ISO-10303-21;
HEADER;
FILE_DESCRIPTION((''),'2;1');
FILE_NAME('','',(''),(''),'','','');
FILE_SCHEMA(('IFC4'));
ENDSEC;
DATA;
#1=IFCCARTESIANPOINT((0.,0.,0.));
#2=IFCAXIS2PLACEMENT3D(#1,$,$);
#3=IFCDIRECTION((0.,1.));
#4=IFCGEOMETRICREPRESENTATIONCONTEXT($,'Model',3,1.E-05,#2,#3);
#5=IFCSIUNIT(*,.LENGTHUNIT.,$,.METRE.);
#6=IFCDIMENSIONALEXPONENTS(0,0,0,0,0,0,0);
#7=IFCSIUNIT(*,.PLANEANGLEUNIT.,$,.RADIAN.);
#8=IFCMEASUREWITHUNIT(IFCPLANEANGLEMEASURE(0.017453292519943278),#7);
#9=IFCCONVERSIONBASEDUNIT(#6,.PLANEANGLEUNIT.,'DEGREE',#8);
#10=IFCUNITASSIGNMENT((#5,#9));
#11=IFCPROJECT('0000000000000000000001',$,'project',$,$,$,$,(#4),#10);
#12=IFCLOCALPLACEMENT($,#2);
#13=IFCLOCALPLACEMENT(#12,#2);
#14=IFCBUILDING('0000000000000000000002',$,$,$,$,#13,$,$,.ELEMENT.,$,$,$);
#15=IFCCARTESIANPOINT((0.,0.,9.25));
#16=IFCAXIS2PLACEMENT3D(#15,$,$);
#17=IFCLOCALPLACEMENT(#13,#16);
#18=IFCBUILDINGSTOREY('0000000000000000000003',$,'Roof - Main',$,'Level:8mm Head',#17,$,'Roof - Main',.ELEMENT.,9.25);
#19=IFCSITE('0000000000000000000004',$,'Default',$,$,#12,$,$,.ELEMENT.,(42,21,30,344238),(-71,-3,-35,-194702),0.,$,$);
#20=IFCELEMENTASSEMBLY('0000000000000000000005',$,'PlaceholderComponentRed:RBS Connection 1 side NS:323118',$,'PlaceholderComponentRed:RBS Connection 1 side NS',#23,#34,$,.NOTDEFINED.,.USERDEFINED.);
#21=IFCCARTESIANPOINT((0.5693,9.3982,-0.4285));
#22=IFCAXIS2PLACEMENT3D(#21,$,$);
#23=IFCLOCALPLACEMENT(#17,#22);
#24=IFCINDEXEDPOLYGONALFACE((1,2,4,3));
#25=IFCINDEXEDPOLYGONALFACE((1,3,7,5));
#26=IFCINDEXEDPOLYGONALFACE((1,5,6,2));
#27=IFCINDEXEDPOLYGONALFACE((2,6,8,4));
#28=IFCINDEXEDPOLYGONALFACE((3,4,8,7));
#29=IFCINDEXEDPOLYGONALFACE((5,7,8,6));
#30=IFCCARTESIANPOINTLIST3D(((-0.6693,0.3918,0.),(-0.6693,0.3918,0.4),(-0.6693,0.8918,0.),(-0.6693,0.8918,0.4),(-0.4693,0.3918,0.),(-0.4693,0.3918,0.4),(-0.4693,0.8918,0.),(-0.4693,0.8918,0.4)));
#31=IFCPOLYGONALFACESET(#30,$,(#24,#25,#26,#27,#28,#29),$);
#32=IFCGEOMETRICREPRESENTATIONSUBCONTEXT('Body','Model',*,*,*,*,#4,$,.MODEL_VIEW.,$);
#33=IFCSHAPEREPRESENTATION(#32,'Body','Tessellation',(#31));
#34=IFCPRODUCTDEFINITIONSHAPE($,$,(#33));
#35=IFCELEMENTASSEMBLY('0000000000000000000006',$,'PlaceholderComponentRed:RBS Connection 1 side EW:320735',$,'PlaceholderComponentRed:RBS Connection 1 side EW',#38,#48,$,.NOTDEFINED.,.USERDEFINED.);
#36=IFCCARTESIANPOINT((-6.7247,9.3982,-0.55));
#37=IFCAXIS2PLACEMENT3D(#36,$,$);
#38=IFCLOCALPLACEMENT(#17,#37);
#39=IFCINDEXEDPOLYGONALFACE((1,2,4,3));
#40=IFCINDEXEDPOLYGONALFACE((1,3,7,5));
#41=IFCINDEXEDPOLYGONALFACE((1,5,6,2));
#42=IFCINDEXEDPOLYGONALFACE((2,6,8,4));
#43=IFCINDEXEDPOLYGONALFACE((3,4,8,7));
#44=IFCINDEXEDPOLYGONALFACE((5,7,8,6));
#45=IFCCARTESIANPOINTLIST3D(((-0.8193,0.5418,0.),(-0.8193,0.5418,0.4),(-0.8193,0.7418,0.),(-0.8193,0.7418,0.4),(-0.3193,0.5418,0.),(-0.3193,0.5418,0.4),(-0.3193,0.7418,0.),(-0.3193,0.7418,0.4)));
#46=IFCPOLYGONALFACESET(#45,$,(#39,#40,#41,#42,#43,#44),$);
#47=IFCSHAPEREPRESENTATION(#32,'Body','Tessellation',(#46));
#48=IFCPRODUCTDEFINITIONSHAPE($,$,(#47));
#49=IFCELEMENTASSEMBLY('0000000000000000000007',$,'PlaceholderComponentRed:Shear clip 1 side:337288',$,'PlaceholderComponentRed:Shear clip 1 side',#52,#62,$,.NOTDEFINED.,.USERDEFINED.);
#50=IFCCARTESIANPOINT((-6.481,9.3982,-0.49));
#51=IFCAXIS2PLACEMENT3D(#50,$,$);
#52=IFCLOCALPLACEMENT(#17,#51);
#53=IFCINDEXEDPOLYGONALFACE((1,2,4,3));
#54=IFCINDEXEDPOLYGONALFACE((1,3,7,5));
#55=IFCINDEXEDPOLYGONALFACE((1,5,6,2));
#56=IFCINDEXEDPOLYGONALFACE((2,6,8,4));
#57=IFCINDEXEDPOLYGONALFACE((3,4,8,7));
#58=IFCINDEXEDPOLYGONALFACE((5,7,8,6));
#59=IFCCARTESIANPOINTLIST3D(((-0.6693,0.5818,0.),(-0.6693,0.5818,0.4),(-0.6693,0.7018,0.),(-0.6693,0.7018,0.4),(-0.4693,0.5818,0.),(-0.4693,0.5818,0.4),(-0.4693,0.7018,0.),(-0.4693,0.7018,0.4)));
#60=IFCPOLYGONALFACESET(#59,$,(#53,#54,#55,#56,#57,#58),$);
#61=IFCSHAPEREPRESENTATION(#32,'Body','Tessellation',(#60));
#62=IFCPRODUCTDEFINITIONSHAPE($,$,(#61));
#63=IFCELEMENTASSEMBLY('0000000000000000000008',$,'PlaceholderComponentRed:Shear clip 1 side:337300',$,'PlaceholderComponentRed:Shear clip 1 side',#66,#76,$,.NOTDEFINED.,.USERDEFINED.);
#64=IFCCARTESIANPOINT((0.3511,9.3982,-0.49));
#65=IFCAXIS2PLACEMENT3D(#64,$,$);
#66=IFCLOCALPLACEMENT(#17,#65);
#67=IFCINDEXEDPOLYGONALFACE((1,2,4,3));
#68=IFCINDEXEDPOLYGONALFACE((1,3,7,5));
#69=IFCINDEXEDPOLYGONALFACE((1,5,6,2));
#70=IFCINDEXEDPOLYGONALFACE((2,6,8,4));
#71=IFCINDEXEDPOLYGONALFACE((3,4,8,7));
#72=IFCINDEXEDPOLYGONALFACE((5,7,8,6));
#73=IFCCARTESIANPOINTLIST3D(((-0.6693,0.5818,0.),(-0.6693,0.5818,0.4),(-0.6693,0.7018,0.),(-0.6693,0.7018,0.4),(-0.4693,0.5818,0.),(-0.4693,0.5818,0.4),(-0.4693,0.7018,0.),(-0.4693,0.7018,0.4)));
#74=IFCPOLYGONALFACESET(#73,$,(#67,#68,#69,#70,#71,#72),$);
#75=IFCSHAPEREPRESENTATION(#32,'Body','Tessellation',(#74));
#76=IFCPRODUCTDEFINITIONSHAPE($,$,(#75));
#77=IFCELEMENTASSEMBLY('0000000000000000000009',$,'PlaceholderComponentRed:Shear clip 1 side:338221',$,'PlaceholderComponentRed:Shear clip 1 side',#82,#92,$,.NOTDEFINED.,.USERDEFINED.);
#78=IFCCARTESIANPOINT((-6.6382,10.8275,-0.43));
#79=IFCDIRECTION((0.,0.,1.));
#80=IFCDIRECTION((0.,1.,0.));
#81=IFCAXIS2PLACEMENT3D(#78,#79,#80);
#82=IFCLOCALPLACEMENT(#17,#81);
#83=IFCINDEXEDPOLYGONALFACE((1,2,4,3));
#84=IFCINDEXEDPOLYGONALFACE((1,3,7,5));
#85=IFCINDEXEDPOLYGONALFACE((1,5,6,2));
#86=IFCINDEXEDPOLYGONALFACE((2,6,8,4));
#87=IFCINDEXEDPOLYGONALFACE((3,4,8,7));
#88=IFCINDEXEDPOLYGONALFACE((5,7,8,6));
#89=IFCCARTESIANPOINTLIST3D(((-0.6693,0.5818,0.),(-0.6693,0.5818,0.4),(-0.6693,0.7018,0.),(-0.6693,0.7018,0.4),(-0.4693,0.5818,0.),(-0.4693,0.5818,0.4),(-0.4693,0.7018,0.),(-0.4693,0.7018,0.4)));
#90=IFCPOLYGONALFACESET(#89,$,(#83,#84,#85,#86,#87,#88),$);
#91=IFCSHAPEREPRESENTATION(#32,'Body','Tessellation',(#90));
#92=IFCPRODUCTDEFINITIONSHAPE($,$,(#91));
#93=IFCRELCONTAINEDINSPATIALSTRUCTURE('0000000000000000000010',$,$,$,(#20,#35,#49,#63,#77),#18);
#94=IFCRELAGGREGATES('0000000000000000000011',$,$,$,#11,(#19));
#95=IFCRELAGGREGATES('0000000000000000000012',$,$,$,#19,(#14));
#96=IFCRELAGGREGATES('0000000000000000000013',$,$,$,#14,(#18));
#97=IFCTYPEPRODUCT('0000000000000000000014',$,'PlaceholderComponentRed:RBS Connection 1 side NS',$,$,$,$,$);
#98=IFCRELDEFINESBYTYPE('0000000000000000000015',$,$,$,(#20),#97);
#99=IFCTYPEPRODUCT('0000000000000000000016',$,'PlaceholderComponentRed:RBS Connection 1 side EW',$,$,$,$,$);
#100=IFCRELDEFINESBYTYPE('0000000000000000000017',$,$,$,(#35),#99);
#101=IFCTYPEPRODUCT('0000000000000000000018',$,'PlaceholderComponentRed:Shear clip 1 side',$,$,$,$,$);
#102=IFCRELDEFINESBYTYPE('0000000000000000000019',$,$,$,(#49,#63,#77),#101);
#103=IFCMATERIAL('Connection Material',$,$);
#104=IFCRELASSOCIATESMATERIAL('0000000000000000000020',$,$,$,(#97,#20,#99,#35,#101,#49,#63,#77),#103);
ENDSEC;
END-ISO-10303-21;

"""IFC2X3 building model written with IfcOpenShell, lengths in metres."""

from ifc_helpers import new_model, entity, si_unit, converted_unit, direction, frame, frame_2d, origin, place, context, subcontext, project, spatial, rectangle, extrude, source, transform, mapped, material, type_object, type_shapes, element, save


model = new_model("IFC2X3")

# Units and contexts
model_context = context("Model", 3, precision=1e-05, world=origin(), true_north=direction((0.0, 1.0)))
body_context = subcontext(model_context, "Body", "Model", "MODEL_VIEW")
ifc_project = project(units=[si_unit("LENGTHUNIT", "METRE"), converted_unit("PLANEANGLEUNIT", "DEGREE", entity("IfcPlaneAngleMeasure", 0.017453292519943278), si_unit("PLANEANGLEUNIT", "RADIAN"), dimensions=[0, 0, 0, 0, 0, 0, 0])], contexts=[model_context])

# Site, building, storey
site_placement = place(None, origin())
site = spatial("IfcSite", under=ifc_project, at=site_placement, Name="Default", CompositionType="ELEMENT", RefLatitude=(42, 21, 30, 344238), RefLongitude=(-71, -3, -35, -194702), RefElevation=0.0)
building_placement = place(site_placement, origin())
building = spatial("IfcBuilding", under=site, at=building_placement, CompositionType="ELEMENT")
storey_placement = place(building_placement, frame((0.0, 0.0, 9.25)))
storey = spatial("IfcBuildingStorey", under=building, at=storey_placement, Name="Roof - Main", ObjectType="Level:8mm Head", LongName="Roof - Main", CompositionType="ELEMENT", Elevation=9.25)

# Element assemblies
ifc_material_1 = material(Name="Connection Material")
type_product_1 = type_object("IfcTypeProduct", Name="PlaceholderComponentRed:RBS Connection 1 side NS", material=ifc_material_1)
shared_shape_1 = source(origin(), body_context, "Body", "SweptSolid", [
    extrude(rectangle(XDim=0.5, YDim=0.2, at=frame_2d((0.0, 0.0), x_axis=(1.0, 0.0))), frame((-0.5693, 0.6418, 0.0), z_axis=(0.0, 0.0, 1.0), x_axis=(0.0, 1.0, 0.0)), (0.0, 0.0, 1.0), 0.4),
])
type_shapes(type_product_1, [shared_shape_1])
assembly_1_placement = place(storey_placement, frame((0.5693, 9.3982, -0.4285)))
element("IfcElementAssembly", 1, at=assembly_1_placement, inside=storey, type_object=type_product_1, material=ifc_material_1, Name="PlaceholderComponentRed:RBS Connection 1 side NS:323118", ObjectType="PlaceholderComponentRed:RBS Connection 1 side NS", AssemblyPlace="NOTDEFINED", PredefinedType="USERDEFINED", context=body_context, shape_type="MappedRepresentation", body=[
    mapped(shared_shape_1, transform((0.0, 0.0, 0.0), scale=1.0)),
])
type_product_2 = type_object("IfcTypeProduct", Name="PlaceholderComponentRed:RBS Connection 1 side EW", material=ifc_material_1)
shared_shape_2 = source(origin(), body_context, "Body", "SweptSolid", [
    extrude(rectangle(XDim=0.2, YDim=0.5, at=frame_2d((0.0, 0.0), x_axis=(1.0, 0.0))), frame((-0.5693, 0.6418, 0.0), z_axis=(0.0, 0.0, 1.0), x_axis=(0.0, 1.0, 0.0)), (0.0, 0.0, 1.0), 0.4),
])
type_shapes(type_product_2, [shared_shape_2])
assembly_2_placement = place(storey_placement, frame((-6.7247, 9.3982, -0.55)))
element("IfcElementAssembly", 2, at=assembly_2_placement, inside=storey, type_object=type_product_2, material=ifc_material_1, Name="PlaceholderComponentRed:RBS Connection 1 side EW:320735", ObjectType="PlaceholderComponentRed:RBS Connection 1 side EW", AssemblyPlace="NOTDEFINED", PredefinedType="USERDEFINED", context=body_context, shape_type="MappedRepresentation", body=[
    mapped(shared_shape_2, transform((0.0, 0.0, 0.0), scale=1.0)),
])
type_product_3 = type_object("IfcTypeProduct", Name="PlaceholderComponentRed:Shear clip 1 side", material=ifc_material_1)
shared_shape_3 = source(origin(), body_context, "Body", "SweptSolid", [
    extrude(rectangle(XDim=0.12, YDim=0.2, at=frame_2d((0.0, 0.0), x_axis=(1.0, 0.0))), frame((-0.5693, 0.6418, 0.0), z_axis=(0.0, 0.0, 1.0), x_axis=(0.0, 1.0, 0.0)), (0.0, 0.0, 1.0), 0.4),
])
type_shapes(type_product_3, [shared_shape_3])
for number, where, name in (
    (3, (-6.481, 9.3982, -0.49), "PlaceholderComponentRed:Shear clip 1 side:337288"),
    (4, (0.3511, 9.3982, -0.49), "PlaceholderComponentRed:Shear clip 1 side:337300"),
):
    element("IfcElementAssembly", number, at=place(storey_placement, frame(where)), inside=storey, type_object=type_product_3, material=ifc_material_1, Name=name, ObjectType="PlaceholderComponentRed:Shear clip 1 side", AssemblyPlace="NOTDEFINED", PredefinedType="USERDEFINED", context=body_context, shape_type="MappedRepresentation", body=[
        mapped(shared_shape_3, transform((0.0, 0.0, 0.0), scale=1.0)),
    ])
assembly_3_placement = place(storey_placement, frame((-6.6382, 10.8275, -0.43), z_axis=(0.0, 0.0, 1.0), x_axis=(0.0, 1.0, 0.0)))
element("IfcElementAssembly", 5, at=assembly_3_placement, inside=storey, type_object=type_product_3, material=ifc_material_1, Name="PlaceholderComponentRed:Shear clip 1 side:338221", ObjectType="PlaceholderComponentRed:Shear clip 1 side", AssemblyPlace="NOTDEFINED", PredefinedType="USERDEFINED", context=body_context, shape_type="MappedRepresentation", body=[
    mapped(shared_shape_3, transform((0.0, 0.0, 0.0), scale=1.0)),
])

save(model, "model.ifc")
